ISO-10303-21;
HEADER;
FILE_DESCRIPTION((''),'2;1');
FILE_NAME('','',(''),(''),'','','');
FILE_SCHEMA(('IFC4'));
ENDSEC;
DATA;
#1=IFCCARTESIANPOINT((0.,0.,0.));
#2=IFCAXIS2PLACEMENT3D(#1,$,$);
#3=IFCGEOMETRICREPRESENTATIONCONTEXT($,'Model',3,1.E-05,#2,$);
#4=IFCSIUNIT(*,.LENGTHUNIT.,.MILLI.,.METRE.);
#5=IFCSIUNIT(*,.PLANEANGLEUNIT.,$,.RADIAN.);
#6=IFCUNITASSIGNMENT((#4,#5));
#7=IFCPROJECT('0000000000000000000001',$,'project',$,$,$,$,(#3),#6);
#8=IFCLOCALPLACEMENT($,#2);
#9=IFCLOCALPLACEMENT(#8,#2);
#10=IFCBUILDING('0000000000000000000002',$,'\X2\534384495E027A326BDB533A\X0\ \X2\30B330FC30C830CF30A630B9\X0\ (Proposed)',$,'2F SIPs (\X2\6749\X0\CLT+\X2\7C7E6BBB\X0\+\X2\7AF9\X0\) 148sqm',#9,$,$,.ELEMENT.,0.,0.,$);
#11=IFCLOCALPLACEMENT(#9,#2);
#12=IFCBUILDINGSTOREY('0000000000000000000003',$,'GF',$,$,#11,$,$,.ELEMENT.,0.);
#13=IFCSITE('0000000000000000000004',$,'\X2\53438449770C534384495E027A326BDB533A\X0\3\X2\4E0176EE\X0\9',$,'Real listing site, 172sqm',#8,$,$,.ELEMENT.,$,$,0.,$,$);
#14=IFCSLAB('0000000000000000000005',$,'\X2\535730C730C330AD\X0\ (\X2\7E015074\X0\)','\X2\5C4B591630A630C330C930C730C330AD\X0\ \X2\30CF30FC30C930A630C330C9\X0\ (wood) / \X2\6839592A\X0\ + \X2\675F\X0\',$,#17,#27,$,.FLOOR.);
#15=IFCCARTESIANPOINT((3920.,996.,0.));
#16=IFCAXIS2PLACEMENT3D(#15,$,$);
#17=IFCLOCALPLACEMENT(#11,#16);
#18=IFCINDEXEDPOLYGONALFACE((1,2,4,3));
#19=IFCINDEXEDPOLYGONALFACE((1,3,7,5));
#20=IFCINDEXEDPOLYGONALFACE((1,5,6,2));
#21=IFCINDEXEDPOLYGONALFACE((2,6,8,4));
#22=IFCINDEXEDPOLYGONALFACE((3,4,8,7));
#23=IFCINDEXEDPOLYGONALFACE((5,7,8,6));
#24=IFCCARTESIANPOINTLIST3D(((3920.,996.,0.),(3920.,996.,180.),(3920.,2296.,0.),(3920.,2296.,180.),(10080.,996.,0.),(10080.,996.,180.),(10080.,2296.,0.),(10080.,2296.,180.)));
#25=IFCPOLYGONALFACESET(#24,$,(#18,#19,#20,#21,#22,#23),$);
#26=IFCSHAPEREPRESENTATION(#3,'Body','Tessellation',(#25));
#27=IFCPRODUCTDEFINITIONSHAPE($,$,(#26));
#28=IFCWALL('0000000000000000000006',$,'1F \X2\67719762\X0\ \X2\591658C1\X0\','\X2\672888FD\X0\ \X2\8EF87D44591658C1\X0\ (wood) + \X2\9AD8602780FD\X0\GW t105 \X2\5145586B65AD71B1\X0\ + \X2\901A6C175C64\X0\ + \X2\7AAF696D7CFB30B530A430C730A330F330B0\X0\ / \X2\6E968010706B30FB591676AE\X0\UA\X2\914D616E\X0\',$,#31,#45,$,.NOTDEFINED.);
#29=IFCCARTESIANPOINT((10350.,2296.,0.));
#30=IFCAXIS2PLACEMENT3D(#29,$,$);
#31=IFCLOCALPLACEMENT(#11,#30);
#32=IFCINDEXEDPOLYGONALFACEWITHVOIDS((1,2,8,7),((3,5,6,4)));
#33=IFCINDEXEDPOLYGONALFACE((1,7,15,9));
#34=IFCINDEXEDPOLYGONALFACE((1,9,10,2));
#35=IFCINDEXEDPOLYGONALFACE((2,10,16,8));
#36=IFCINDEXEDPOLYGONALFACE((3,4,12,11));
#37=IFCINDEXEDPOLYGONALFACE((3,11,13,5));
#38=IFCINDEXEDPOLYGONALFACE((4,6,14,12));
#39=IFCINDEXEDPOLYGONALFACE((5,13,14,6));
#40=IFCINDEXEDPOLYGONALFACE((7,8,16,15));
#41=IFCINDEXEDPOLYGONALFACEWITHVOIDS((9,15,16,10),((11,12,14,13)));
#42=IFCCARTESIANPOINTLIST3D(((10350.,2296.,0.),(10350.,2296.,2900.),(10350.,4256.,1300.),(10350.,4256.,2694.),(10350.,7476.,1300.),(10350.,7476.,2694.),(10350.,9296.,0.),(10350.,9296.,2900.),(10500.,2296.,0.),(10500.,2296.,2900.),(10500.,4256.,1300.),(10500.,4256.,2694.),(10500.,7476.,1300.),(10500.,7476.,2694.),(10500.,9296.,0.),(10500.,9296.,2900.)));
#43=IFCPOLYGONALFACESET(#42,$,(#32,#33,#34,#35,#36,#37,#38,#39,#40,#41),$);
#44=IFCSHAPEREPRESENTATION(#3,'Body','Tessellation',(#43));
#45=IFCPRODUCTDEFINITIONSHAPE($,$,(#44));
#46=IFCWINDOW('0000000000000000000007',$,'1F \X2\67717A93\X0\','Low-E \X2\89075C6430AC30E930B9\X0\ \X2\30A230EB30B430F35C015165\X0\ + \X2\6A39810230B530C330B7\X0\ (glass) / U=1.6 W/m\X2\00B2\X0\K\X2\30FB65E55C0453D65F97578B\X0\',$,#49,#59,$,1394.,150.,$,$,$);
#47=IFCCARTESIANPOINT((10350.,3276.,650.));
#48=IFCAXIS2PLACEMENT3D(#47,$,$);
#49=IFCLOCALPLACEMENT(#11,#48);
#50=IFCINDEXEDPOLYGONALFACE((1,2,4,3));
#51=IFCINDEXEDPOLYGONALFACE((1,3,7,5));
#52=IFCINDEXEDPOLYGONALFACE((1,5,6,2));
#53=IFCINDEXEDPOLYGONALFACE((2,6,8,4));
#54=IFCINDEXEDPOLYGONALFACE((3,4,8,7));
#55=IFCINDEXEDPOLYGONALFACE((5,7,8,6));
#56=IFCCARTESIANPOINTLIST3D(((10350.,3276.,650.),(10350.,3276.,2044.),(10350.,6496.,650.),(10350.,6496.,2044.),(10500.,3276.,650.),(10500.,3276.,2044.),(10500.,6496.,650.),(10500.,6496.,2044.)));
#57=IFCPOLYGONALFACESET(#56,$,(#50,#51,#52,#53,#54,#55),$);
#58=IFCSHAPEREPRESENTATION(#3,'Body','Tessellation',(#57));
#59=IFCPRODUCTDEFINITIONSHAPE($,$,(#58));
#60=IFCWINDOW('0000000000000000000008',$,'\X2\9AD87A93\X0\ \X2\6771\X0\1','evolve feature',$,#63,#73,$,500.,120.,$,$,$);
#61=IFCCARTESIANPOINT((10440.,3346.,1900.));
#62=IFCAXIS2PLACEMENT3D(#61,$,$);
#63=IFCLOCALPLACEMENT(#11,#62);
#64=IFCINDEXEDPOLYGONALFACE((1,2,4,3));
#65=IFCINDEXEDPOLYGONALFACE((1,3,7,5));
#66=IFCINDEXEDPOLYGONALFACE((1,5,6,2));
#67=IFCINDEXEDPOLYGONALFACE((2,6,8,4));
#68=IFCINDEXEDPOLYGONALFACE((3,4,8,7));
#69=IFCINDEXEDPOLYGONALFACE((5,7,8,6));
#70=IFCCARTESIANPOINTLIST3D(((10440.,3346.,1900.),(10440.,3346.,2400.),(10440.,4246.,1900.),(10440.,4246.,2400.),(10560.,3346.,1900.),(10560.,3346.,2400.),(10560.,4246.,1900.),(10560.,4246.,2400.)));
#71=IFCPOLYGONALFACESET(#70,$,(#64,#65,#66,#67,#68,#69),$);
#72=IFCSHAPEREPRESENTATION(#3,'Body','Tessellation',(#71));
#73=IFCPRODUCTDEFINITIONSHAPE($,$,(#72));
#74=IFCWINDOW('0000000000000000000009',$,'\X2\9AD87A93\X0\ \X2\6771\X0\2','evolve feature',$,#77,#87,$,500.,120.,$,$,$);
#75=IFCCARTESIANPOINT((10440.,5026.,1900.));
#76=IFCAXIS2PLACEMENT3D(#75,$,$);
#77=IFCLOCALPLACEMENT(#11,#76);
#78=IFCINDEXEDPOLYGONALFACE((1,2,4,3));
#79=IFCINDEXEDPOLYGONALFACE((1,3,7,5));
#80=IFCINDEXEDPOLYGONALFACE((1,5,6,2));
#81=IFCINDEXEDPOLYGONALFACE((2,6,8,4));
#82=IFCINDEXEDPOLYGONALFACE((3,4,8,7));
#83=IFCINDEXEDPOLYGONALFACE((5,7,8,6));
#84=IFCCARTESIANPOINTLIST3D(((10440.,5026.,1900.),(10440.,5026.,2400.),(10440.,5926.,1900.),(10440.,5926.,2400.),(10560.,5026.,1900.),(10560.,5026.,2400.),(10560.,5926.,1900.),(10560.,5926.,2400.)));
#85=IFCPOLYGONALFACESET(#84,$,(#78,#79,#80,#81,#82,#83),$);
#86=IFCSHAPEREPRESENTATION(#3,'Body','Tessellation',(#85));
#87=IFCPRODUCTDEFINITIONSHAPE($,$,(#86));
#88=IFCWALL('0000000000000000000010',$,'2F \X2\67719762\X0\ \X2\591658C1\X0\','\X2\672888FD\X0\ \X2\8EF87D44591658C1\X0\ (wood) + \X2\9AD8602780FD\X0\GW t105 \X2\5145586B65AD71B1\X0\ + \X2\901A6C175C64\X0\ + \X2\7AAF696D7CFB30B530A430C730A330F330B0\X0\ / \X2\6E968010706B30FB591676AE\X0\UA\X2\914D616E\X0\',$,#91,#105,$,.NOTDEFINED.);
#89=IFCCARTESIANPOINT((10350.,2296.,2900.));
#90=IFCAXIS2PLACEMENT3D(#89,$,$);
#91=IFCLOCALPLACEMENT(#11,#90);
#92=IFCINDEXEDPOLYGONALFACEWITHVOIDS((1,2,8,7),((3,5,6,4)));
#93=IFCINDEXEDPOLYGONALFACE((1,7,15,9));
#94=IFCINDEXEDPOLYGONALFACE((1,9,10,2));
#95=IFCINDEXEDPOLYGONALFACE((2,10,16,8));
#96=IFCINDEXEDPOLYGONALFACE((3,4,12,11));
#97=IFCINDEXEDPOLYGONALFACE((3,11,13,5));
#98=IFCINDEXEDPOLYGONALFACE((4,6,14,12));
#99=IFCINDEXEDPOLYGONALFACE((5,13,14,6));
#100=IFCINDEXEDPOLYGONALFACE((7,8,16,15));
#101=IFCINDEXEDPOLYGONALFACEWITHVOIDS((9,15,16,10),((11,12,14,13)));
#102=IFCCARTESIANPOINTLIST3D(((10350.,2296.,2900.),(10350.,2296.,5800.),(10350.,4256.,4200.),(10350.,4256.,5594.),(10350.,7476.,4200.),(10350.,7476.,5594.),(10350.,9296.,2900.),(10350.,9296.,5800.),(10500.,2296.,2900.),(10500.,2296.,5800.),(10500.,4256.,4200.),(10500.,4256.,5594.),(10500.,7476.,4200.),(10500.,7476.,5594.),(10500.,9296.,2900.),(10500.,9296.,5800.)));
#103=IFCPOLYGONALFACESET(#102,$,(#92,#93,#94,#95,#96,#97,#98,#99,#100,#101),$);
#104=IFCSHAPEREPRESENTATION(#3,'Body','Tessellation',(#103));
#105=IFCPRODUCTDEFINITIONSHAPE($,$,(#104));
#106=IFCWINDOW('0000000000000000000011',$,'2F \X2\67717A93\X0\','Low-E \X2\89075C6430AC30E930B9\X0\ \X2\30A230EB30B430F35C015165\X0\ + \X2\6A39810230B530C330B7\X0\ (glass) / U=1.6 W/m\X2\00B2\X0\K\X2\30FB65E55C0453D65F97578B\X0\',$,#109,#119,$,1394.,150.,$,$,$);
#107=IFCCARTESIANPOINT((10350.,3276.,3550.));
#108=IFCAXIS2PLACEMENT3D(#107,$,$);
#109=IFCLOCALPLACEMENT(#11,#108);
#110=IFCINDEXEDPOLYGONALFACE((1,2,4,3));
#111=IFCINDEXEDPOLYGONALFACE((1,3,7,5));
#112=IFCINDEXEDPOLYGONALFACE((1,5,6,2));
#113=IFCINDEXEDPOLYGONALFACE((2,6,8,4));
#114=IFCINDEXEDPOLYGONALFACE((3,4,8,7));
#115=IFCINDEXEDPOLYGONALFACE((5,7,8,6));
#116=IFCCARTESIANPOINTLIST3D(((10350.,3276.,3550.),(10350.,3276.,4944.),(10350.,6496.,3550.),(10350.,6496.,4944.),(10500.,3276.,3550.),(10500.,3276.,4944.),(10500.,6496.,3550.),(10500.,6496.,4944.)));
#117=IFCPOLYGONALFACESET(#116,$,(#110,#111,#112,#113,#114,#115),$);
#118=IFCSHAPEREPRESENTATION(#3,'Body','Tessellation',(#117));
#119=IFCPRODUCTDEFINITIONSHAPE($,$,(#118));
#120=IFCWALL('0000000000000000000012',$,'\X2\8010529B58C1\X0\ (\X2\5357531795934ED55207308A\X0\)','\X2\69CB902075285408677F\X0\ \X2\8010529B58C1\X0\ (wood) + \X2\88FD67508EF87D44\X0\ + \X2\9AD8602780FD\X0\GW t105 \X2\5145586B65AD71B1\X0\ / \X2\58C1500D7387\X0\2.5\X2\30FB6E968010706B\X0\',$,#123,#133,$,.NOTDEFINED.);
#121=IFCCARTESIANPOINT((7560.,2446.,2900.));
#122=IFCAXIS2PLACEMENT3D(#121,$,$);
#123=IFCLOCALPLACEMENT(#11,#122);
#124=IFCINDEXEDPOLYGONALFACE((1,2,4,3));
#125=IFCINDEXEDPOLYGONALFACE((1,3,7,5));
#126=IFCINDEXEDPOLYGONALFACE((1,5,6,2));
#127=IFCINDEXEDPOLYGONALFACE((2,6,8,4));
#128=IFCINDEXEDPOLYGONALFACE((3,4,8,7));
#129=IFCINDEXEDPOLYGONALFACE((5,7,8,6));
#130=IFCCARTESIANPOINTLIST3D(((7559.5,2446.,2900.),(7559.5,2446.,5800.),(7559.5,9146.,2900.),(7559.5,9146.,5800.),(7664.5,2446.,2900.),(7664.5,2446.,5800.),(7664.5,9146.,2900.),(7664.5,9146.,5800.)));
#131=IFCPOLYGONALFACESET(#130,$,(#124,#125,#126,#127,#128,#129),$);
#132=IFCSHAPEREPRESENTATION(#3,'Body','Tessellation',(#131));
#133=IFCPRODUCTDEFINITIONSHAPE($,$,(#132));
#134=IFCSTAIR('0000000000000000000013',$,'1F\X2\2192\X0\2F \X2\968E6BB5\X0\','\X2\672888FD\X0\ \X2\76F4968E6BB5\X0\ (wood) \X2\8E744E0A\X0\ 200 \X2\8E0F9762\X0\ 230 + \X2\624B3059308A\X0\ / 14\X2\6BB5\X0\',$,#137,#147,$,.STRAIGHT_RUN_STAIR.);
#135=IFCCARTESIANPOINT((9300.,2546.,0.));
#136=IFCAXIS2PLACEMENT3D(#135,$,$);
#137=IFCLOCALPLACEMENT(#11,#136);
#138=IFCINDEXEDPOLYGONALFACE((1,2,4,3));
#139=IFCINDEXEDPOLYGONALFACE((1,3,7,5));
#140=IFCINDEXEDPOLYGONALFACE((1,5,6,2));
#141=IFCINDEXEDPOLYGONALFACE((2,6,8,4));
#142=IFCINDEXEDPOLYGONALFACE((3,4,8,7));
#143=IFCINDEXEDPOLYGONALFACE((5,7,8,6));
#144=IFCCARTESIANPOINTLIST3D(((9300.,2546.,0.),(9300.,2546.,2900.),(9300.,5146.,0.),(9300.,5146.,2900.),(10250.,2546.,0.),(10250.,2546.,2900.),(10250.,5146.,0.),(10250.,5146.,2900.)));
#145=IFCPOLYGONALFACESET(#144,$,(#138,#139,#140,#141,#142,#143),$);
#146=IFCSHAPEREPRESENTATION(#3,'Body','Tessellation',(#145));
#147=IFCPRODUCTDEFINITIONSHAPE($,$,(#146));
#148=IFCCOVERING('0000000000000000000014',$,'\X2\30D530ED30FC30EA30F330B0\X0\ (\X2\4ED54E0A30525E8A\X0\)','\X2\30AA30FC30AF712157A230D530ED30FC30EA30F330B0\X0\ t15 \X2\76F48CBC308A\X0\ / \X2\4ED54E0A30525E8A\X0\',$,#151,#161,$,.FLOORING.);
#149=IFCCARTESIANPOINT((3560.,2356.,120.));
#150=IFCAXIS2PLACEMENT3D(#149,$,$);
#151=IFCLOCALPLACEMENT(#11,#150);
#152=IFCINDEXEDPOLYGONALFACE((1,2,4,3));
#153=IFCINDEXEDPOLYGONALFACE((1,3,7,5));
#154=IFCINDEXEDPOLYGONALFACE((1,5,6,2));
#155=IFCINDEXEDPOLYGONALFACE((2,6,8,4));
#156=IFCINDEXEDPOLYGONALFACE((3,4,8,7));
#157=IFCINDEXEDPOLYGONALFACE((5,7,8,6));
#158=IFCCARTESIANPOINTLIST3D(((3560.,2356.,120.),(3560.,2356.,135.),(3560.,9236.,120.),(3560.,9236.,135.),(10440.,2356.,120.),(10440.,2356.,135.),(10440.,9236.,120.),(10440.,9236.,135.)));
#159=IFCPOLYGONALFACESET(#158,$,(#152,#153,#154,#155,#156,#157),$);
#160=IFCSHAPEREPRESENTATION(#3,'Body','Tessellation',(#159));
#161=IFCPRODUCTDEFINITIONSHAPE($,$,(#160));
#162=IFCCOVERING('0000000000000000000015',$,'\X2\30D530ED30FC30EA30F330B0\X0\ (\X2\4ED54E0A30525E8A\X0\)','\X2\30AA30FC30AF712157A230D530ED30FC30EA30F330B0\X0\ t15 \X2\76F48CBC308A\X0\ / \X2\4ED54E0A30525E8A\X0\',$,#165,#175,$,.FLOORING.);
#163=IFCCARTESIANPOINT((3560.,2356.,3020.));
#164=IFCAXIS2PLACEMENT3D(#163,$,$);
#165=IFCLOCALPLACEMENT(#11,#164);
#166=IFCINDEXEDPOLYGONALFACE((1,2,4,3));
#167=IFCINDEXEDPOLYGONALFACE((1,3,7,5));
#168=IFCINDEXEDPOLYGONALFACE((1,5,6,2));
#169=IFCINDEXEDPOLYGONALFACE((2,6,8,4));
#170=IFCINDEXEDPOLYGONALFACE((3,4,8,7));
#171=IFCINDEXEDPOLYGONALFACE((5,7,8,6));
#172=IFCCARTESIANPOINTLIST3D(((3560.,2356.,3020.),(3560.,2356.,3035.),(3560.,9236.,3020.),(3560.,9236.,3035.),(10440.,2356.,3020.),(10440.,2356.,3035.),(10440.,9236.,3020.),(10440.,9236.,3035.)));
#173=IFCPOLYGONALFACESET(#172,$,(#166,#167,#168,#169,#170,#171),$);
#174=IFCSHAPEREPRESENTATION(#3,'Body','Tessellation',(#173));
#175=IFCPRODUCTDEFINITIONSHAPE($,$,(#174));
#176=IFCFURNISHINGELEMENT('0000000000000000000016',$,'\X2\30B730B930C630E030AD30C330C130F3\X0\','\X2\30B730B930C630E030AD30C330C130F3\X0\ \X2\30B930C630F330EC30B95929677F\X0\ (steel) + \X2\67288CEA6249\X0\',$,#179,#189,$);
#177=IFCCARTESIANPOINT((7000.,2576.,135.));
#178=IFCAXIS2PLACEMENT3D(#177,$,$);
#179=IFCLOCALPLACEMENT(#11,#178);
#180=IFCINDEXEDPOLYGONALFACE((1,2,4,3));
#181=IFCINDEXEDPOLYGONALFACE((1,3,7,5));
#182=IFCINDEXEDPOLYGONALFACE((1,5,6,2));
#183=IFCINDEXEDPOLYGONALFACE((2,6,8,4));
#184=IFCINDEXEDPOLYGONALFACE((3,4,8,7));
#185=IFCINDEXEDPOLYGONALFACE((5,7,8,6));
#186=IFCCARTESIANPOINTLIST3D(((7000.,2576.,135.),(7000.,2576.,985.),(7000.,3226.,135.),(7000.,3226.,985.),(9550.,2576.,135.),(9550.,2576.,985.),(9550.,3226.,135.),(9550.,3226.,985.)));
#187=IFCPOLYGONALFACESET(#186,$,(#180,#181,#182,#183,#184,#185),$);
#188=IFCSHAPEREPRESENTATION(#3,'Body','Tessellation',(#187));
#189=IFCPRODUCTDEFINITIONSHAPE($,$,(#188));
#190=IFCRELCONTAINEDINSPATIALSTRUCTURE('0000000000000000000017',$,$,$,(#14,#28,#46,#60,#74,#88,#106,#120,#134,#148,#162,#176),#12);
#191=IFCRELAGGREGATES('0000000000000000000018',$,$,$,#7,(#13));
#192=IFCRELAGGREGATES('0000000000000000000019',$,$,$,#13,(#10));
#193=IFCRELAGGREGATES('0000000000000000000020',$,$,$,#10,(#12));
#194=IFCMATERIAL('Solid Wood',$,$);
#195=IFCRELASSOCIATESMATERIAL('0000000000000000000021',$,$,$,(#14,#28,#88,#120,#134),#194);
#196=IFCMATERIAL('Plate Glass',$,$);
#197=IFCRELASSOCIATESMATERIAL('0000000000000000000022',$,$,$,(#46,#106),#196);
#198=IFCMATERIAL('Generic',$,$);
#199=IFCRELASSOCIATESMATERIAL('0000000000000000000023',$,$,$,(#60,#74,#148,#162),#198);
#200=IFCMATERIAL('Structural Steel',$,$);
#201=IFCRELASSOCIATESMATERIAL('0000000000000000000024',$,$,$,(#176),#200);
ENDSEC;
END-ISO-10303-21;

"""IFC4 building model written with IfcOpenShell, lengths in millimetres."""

from ifc_helpers import new_model, si_unit, frame, frame_2d, origin, place, context, project, spatial, rectangle, extrude, material, element, fill, save


model = new_model("IFC4")

# Units and contexts
model_context = context("Model", 3, precision=1e-05, world=origin())
ifc_project = project(units=[si_unit("LENGTHUNIT", "METRE", prefix="MILLI"), si_unit("PLANEANGLEUNIT", "RADIAN")], contexts=[model_context])

# Site, building, storey
site_placement = place(None, origin())
site = spatial("IfcSite", under=ifc_project, at=site_placement, Name="千葉県千葉市稲毛区3丁目9", ObjectType="Real listing site, 172sqm", CompositionType="ELEMENT", RefElevation=0.0)
building_placement = place(site_placement, origin())
building = spatial("IfcBuilding", under=site, at=building_placement, Name="千葉市稲毛区 コートハウス (Proposed)", ObjectType="2F SIPs (杉CLT+籾殻+竹) 148sqm", CompositionType="ELEMENT", ElevationOfRefHeight=0.0, ElevationOfTerrain=0.0)
storey_placement = place(building_placement, origin())
storey = spatial("IfcBuildingStorey", under=building, at=storey_placement, Name="GF", CompositionType="ELEMENT", Elevation=0.0)

# Slab
ifc_material_1 = material(Name="Solid Wood")
slab_placement = place(storey_placement, frame((3920.0, 996.0, 0.0)))
element("IfcSlab", 1, at=slab_placement, inside=storey, material=ifc_material_1, Name="南デッキ (縁側)", Description="屋外ウッドデッキ ハードウッド (wood) / 根太 + 束", PredefinedType="FLOOR", context=model_context, shape_type="SweptSolid", body=[
    extrude(rectangle(XDim=6160.0, YDim=1300.0, at=frame_2d((3080.0, 650.0))), frame((3920.0, 996.0, 0.0)), (0.0, 0.0, 1.0), 180.0),
])

# Wall, openings, windows
wall_1_placement = place(storey_placement, frame((10350.0, 2296.0, 0.0)))
wall_1 = element("IfcWall", 2, at=wall_1_placement, inside=storey, material=ifc_material_1, Name="1F 東面 外壁", Description="木製 軸組外壁 (wood) + 高性能GW t105 充填断熱 + 通気層 + 窯業系サイディング / 準耐火・外皮UA配慮", PredefinedType="NOTDEFINED", context=model_context, shape_type="SweptSolid", body=[
    extrude(rectangle(XDim=150.0, YDim=7000.0, at=frame_2d((75.0, 3500.0))), frame((10350.0, 2296.0, 0.0)), (0.0, 0.0, 1.0), 2900.0),
])
opening_1_placement = place(storey_placement, frame((10350.0, 3276.0, 650.0)))
opening_1 = element("IfcOpeningElement", 3, at=opening_1_placement, cuts=wall_1, PredefinedType="NOTDEFINED", context=model_context, shape_type="SweptSolid", body=[
    extrude(rectangle(XDim=150.0, YDim=3220.0, at=frame_2d((75.0, 1610.0))), frame((10350.0, 3276.0, 650.0)), (0.0, 0.0, 1.0), 1394.0),
])
opening_2_placement = place(storey_placement, frame((10440.0, 3346.0, 1900.0)))
opening_2 = element("IfcOpeningElement", 4, at=opening_2_placement, cuts=wall_1, PredefinedType="NOTDEFINED", context=model_context, shape_type="SweptSolid", body=[
    extrude(rectangle(XDim=120.0, YDim=900.0, at=frame_2d((60.0, 450.0))), frame((10440.0, 3346.0, 1900.0)), (0.0, 0.0, 1.0), 500.0),
])
opening_3_placement = place(storey_placement, frame((10440.0, 5026.0, 1900.0)))
opening_3 = element("IfcOpeningElement", 5, at=opening_3_placement, cuts=wall_1, PredefinedType="NOTDEFINED", context=model_context, shape_type="SweptSolid", body=[
    extrude(rectangle(XDim=120.0, YDim=900.0, at=frame_2d((60.0, 450.0))), frame((10440.0, 5026.0, 1900.0)), (0.0, 0.0, 1.0), 500.0),
])
ifc_material_2 = material(Name="Plate Glass")
window_1_placement = place(storey_placement, frame((10350.0, 3276.0, 650.0)))
window_1 = element("IfcWindow", 6, at=window_1_placement, inside=storey, material=ifc_material_2, Name="1F 東窓", Description="Low-E 複層ガラス アルゴン封入 + 樹脂サッシ (glass) / U=1.6 W/m²K・日射取得型", OverallHeight=1394.0, OverallWidth=150.0, context=model_context, shape_type="SweptSolid", body=[
    extrude(rectangle(XDim=150.0, YDim=3220.0, at=frame_2d((75.0, 1610.0))), frame((10350.0, 3276.0, 650.0)), (0.0, 0.0, 1.0), 1394.0),
])
fill(opening_1, window_1)
ifc_material_3 = material(Name="Generic")
window_2_placement = place(storey_placement, frame((10440.0, 3346.0, 1900.0)))
window_2 = element("IfcWindow", 7, at=window_2_placement, inside=storey, material=ifc_material_3, Name="高窓 東1", Description="evolve feature", OverallHeight=500.0, OverallWidth=120.0, context=model_context, shape_type="SweptSolid", body=[
    extrude(rectangle(XDim=120.0, YDim=900.0, at=frame_2d((60.0, 450.0))), frame((10440.0, 3346.0, 1900.0)), (0.0, 0.0, 1.0), 500.0),
])
fill(opening_2, window_2)
window_3_placement = place(storey_placement, frame((10440.0, 5026.0, 1900.0)))
window_3 = element("IfcWindow", 8, at=window_3_placement, inside=storey, material=ifc_material_3, Name="高窓 東2", Description="evolve feature", OverallHeight=500.0, OverallWidth=120.0, context=model_context, shape_type="SweptSolid", body=[
    extrude(rectangle(XDim=120.0, YDim=900.0, at=frame_2d((60.0, 450.0))), frame((10440.0, 5026.0, 1900.0)), (0.0, 0.0, 1.0), 500.0),
])
fill(opening_3, window_3)

# Wall, opening, window
wall_2_placement = place(storey_placement, frame((10350.0, 2296.0, 2900.0)))
wall_2 = element("IfcWall", 9, at=wall_2_placement, inside=storey, material=ifc_material_1, Name="2F 東面 外壁", Description="木製 軸組外壁 (wood) + 高性能GW t105 充填断熱 + 通気層 + 窯業系サイディング / 準耐火・外皮UA配慮", PredefinedType="NOTDEFINED", context=model_context, shape_type="SweptSolid", body=[
    extrude(rectangle(XDim=150.0, YDim=7000.0, at=frame_2d((75.0, 3500.0))), frame((10350.0, 2296.0, 2900.0)), (0.0, 0.0, 1.0), 2900.0),
])
opening_4_placement = place(storey_placement, frame((10350.0, 3276.0, 3550.0)))
opening_4 = element("IfcOpeningElement", 10, at=opening_4_placement, cuts=wall_2, PredefinedType="NOTDEFINED", context=model_context, shape_type="SweptSolid", body=[
    extrude(rectangle(XDim=150.0, YDim=3220.0, at=frame_2d((75.0, 1610.0))), frame((10350.0, 3276.0, 3550.0)), (0.0, 0.0, 1.0), 1394.0),
])
window_4_placement = place(storey_placement, frame((10350.0, 3276.0, 3550.0)))
window_4 = element("IfcWindow", 11, at=window_4_placement, inside=storey, material=ifc_material_2, Name="2F 東窓", Description="Low-E 複層ガラス アルゴン封入 + 樹脂サッシ (glass) / U=1.6 W/m²K・日射取得型", OverallHeight=1394.0, OverallWidth=150.0, context=model_context, shape_type="SweptSolid", body=[
    extrude(rectangle(XDim=150.0, YDim=3220.0, at=frame_2d((75.0, 1610.0))), frame((10350.0, 3276.0, 3550.0)), (0.0, 0.0, 1.0), 1394.0),
])
fill(opening_4, window_4)

# Wall
wall_3_placement = place(storey_placement, frame((7560.0, 2446.0, 2900.0)))
element("IfcWall", 12, at=wall_3_placement, inside=storey, material=ifc_material_1, Name="耐力壁 (南北間仕切り)", Description="構造用合板 耐力壁 (wood) + 製材軸組 + 高性能GW t105 充填断熱 / 壁倍率2.5・準耐火", PredefinedType="NOTDEFINED", context=model_context, shape_type="SweptSolid", body=[
    extrude(rectangle(XDim=105.0, YDim=6700.0, at=frame_2d((52.0, 3350.0))), frame((7560.0, 2446.0, 2900.0)), (0.0, 0.0, 1.0), 2900.0),
])

# Stair
stair_placement = place(storey_placement, frame((9300.0, 2546.0, 0.0)))
element("IfcStair", 13, at=stair_placement, inside=storey, material=ifc_material_1, Name="1F→2F 階段", Description="木製 直階段 (wood) 蹴上 200 踏面 230 + 手すり / 14段", PredefinedType="STRAIGHT_RUN_STAIR", context=model_context, shape_type="SweptSolid", body=[
    extrude(rectangle(XDim=950.0, YDim=2600.0, at=frame_2d((475.0, 1300.0))), frame((9300.0, 2546.0, 0.0)), (0.0, 0.0, 1.0), 2900.0),
])

# Coverings
covering_1_placement = place(storey_placement, frame((3560.0, 2356.0, 120.0)))
element("IfcCovering", 14, at=covering_1_placement, inside=storey, material=ifc_material_3, Name="フローリング (仕上げ床)", Description="オーク無垢フローリング t15 直貼り / 仕上げ床", PredefinedType="FLOORING", context=model_context, shape_type="SweptSolid", body=[
    extrude(rectangle(XDim=6880.0, YDim=6880.0, at=frame_2d((3440.0, 3440.0))), frame((3560.0, 2356.0, 120.0)), (0.0, 0.0, 1.0), 15.0),
])
covering_2_placement = place(storey_placement, frame((3560.0, 2356.0, 3020.0)))
element("IfcCovering", 15, at=covering_2_placement, inside=storey, material=ifc_material_3, Name="フローリング (仕上げ床)", Description="オーク無垢フローリング t15 直貼り / 仕上げ床", PredefinedType="FLOORING", context=model_context, shape_type="SweptSolid", body=[
    extrude(rectangle(XDim=6880.0, YDim=6880.0, at=frame_2d((3440.0, 3440.0))), frame((3560.0, 2356.0, 3020.0)), (0.0, 0.0, 1.0), 15.0),
])

# Furnishing element
ifc_material_4 = material(Name="Structural Steel")
furnishing_1_placement = place(storey_placement, frame((7000.0, 2576.0, 135.0)))
element("IfcFurnishingElement", 16, at=furnishing_1_placement, inside=storey, material=ifc_material_4, Name="システムキッチン", Description="システムキッチン ステンレス天板 (steel) + 木質扉", context=model_context, shape_type="SweptSolid", body=[
    extrude(rectangle(XDim=2550.0, YDim=650.0, at=frame_2d((1275.0, 325.0))), frame((7000.0, 2576.0, 135.0)), (0.0, 0.0, 1.0), 850.0),
])

save(model, "model.ifc")
